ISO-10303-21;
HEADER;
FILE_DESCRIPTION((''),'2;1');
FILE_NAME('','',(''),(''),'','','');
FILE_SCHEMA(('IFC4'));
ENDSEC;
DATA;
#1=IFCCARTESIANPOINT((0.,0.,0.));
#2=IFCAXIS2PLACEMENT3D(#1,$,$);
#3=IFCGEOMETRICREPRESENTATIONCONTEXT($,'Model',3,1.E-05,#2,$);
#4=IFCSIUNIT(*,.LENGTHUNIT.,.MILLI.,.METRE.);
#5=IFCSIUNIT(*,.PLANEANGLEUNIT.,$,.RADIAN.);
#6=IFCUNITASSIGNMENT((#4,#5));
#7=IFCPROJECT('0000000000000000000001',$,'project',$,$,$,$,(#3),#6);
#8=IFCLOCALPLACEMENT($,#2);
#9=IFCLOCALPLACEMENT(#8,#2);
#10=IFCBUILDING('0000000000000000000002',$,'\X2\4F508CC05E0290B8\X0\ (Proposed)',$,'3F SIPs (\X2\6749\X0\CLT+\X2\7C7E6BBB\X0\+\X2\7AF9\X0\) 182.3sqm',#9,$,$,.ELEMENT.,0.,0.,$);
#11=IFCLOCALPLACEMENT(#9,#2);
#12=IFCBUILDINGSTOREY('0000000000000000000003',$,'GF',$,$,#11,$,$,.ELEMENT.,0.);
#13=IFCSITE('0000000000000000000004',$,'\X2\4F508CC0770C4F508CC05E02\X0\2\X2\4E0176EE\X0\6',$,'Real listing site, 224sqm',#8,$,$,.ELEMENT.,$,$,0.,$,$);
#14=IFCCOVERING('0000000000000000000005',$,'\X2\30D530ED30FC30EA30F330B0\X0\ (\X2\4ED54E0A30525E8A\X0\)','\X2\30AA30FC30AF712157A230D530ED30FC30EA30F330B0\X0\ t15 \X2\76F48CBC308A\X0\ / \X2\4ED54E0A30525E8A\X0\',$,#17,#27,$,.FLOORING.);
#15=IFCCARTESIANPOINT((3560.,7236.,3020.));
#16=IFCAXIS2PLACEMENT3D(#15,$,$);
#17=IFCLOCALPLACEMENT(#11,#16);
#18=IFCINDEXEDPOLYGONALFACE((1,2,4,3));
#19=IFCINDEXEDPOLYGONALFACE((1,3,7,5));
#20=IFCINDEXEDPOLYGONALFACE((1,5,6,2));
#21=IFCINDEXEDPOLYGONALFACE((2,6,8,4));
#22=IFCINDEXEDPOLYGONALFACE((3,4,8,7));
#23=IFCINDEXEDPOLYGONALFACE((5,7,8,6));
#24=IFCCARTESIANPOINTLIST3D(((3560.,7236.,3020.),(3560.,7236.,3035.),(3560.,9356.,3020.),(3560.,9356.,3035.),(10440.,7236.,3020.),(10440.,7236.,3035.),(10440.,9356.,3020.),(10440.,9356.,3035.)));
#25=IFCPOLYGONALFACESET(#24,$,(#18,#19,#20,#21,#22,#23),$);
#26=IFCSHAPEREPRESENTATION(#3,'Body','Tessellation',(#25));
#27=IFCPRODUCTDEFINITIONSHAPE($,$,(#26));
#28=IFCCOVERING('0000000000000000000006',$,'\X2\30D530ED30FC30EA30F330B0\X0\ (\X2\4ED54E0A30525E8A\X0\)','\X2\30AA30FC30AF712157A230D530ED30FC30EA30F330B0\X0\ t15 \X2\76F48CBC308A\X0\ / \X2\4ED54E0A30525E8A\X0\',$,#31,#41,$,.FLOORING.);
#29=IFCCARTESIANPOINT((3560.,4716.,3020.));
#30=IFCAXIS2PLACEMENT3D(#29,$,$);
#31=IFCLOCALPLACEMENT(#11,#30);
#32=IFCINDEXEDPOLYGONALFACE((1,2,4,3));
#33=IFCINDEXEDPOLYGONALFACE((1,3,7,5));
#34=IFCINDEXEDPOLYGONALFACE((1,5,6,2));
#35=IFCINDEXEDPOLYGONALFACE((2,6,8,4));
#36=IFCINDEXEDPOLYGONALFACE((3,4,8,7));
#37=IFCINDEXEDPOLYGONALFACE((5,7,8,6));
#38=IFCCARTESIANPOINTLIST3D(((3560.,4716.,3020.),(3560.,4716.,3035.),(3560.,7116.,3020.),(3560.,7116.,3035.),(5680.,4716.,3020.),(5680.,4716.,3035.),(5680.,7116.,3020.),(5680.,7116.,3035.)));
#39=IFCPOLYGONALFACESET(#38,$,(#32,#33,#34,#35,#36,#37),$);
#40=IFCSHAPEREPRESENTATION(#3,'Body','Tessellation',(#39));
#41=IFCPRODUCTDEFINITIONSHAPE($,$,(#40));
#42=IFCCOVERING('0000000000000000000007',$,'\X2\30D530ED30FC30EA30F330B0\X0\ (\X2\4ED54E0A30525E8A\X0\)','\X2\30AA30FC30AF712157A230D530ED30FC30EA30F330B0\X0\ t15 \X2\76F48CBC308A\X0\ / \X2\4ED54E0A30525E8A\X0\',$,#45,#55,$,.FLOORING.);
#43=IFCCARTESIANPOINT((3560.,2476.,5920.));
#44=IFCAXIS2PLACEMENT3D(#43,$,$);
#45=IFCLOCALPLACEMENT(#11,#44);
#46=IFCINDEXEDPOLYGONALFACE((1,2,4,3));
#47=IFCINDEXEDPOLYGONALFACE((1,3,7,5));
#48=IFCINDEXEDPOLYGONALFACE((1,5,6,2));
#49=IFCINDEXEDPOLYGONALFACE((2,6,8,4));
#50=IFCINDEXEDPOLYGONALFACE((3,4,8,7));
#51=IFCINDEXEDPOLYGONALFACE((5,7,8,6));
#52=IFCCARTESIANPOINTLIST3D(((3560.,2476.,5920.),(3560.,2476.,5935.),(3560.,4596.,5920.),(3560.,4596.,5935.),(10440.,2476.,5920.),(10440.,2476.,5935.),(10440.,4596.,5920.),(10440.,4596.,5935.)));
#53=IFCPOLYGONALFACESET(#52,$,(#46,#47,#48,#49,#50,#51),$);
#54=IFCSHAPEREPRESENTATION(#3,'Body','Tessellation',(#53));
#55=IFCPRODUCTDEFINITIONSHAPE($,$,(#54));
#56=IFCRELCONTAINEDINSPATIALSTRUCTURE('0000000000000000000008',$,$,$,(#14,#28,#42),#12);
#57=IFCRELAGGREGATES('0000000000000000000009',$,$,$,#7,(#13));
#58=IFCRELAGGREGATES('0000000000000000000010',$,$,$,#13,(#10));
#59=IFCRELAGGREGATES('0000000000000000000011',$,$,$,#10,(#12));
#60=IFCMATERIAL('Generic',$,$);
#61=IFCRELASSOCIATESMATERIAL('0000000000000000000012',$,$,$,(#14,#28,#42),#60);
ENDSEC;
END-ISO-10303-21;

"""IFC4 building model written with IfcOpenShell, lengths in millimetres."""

from ifc_helpers import new_model, si_unit, frame, frame_2d, origin, place, context, project, spatial, rectangle, extrude, material, element, save


model = new_model("IFC4")

# Units and contexts
model_context = context("Model", 3, precision=1e-05, world=origin())
ifc_project = project(units=[si_unit("LENGTHUNIT", "METRE", prefix="MILLI"), si_unit("PLANEANGLEUNIT", "RADIAN")], contexts=[model_context])

# Site, building, storey
site_placement = place(None, origin())
site = spatial("IfcSite", under=ifc_project, at=site_placement, Name="佐賀県佐賀市2丁目6", ObjectType="Real listing site, 224sqm", CompositionType="ELEMENT", RefElevation=0.0)
building_placement = place(site_placement, origin())
building = spatial("IfcBuilding", under=site, at=building_placement, Name="佐賀市邸 (Proposed)", ObjectType="3F SIPs (杉CLT+籾殻+竹) 182.3sqm", CompositionType="ELEMENT", ElevationOfRefHeight=0.0, ElevationOfTerrain=0.0)
storey_placement = place(building_placement, origin())
storey = spatial("IfcBuildingStorey", under=building, at=storey_placement, Name="GF", CompositionType="ELEMENT", Elevation=0.0)

# Shared definitions
ifc_material_1 = material(Name="Generic")

# Coverings
covering_1_placement = place(storey_placement, frame((3560.0, 7236.0, 3020.0)))
element("IfcCovering", 1, at=covering_1_placement, inside=storey, material=ifc_material_1, Name="フローリング (仕上げ床)", Description="オーク無垢フローリング t15 直貼り / 仕上げ床", PredefinedType="FLOORING", context=model_context, shape_type="SweptSolid", body=[
    extrude(rectangle(XDim=6880.0, YDim=2120.0, at=frame_2d((3440.0, 1060.0))), frame((3560.0, 7236.0, 3020.0)), (0.0, 0.0, 1.0), 15.0),
])
covering_2_placement = place(storey_placement, frame((3560.0, 4716.0, 3020.0)))
element("IfcCovering", 2, at=covering_2_placement, inside=storey, material=ifc_material_1, Name="フローリング (仕上げ床)", Description="オーク無垢フローリング t15 直貼り / 仕上げ床", PredefinedType="FLOORING", context=model_context, shape_type="SweptSolid", body=[
    extrude(rectangle(XDim=2120.0, YDim=2400.0, at=frame_2d((1060.0, 1200.0))), frame((3560.0, 4716.0, 3020.0)), (0.0, 0.0, 1.0), 15.0),
])
covering_3_placement = place(storey_placement, frame((3560.0, 2476.0, 5920.0)))
element("IfcCovering", 3, at=covering_3_placement, inside=storey, material=ifc_material_1, Name="フローリング (仕上げ床)", Description="オーク無垢フローリング t15 直貼り / 仕上げ床", PredefinedType="FLOORING", context=model_context, shape_type="SweptSolid", body=[
    extrude(rectangle(XDim=6880.0, YDim=2120.0, at=frame_2d((3440.0, 1060.0))), frame((3560.0, 2476.0, 5920.0)), (0.0, 0.0, 1.0), 15.0),
])

save(model, "model.ifc")
